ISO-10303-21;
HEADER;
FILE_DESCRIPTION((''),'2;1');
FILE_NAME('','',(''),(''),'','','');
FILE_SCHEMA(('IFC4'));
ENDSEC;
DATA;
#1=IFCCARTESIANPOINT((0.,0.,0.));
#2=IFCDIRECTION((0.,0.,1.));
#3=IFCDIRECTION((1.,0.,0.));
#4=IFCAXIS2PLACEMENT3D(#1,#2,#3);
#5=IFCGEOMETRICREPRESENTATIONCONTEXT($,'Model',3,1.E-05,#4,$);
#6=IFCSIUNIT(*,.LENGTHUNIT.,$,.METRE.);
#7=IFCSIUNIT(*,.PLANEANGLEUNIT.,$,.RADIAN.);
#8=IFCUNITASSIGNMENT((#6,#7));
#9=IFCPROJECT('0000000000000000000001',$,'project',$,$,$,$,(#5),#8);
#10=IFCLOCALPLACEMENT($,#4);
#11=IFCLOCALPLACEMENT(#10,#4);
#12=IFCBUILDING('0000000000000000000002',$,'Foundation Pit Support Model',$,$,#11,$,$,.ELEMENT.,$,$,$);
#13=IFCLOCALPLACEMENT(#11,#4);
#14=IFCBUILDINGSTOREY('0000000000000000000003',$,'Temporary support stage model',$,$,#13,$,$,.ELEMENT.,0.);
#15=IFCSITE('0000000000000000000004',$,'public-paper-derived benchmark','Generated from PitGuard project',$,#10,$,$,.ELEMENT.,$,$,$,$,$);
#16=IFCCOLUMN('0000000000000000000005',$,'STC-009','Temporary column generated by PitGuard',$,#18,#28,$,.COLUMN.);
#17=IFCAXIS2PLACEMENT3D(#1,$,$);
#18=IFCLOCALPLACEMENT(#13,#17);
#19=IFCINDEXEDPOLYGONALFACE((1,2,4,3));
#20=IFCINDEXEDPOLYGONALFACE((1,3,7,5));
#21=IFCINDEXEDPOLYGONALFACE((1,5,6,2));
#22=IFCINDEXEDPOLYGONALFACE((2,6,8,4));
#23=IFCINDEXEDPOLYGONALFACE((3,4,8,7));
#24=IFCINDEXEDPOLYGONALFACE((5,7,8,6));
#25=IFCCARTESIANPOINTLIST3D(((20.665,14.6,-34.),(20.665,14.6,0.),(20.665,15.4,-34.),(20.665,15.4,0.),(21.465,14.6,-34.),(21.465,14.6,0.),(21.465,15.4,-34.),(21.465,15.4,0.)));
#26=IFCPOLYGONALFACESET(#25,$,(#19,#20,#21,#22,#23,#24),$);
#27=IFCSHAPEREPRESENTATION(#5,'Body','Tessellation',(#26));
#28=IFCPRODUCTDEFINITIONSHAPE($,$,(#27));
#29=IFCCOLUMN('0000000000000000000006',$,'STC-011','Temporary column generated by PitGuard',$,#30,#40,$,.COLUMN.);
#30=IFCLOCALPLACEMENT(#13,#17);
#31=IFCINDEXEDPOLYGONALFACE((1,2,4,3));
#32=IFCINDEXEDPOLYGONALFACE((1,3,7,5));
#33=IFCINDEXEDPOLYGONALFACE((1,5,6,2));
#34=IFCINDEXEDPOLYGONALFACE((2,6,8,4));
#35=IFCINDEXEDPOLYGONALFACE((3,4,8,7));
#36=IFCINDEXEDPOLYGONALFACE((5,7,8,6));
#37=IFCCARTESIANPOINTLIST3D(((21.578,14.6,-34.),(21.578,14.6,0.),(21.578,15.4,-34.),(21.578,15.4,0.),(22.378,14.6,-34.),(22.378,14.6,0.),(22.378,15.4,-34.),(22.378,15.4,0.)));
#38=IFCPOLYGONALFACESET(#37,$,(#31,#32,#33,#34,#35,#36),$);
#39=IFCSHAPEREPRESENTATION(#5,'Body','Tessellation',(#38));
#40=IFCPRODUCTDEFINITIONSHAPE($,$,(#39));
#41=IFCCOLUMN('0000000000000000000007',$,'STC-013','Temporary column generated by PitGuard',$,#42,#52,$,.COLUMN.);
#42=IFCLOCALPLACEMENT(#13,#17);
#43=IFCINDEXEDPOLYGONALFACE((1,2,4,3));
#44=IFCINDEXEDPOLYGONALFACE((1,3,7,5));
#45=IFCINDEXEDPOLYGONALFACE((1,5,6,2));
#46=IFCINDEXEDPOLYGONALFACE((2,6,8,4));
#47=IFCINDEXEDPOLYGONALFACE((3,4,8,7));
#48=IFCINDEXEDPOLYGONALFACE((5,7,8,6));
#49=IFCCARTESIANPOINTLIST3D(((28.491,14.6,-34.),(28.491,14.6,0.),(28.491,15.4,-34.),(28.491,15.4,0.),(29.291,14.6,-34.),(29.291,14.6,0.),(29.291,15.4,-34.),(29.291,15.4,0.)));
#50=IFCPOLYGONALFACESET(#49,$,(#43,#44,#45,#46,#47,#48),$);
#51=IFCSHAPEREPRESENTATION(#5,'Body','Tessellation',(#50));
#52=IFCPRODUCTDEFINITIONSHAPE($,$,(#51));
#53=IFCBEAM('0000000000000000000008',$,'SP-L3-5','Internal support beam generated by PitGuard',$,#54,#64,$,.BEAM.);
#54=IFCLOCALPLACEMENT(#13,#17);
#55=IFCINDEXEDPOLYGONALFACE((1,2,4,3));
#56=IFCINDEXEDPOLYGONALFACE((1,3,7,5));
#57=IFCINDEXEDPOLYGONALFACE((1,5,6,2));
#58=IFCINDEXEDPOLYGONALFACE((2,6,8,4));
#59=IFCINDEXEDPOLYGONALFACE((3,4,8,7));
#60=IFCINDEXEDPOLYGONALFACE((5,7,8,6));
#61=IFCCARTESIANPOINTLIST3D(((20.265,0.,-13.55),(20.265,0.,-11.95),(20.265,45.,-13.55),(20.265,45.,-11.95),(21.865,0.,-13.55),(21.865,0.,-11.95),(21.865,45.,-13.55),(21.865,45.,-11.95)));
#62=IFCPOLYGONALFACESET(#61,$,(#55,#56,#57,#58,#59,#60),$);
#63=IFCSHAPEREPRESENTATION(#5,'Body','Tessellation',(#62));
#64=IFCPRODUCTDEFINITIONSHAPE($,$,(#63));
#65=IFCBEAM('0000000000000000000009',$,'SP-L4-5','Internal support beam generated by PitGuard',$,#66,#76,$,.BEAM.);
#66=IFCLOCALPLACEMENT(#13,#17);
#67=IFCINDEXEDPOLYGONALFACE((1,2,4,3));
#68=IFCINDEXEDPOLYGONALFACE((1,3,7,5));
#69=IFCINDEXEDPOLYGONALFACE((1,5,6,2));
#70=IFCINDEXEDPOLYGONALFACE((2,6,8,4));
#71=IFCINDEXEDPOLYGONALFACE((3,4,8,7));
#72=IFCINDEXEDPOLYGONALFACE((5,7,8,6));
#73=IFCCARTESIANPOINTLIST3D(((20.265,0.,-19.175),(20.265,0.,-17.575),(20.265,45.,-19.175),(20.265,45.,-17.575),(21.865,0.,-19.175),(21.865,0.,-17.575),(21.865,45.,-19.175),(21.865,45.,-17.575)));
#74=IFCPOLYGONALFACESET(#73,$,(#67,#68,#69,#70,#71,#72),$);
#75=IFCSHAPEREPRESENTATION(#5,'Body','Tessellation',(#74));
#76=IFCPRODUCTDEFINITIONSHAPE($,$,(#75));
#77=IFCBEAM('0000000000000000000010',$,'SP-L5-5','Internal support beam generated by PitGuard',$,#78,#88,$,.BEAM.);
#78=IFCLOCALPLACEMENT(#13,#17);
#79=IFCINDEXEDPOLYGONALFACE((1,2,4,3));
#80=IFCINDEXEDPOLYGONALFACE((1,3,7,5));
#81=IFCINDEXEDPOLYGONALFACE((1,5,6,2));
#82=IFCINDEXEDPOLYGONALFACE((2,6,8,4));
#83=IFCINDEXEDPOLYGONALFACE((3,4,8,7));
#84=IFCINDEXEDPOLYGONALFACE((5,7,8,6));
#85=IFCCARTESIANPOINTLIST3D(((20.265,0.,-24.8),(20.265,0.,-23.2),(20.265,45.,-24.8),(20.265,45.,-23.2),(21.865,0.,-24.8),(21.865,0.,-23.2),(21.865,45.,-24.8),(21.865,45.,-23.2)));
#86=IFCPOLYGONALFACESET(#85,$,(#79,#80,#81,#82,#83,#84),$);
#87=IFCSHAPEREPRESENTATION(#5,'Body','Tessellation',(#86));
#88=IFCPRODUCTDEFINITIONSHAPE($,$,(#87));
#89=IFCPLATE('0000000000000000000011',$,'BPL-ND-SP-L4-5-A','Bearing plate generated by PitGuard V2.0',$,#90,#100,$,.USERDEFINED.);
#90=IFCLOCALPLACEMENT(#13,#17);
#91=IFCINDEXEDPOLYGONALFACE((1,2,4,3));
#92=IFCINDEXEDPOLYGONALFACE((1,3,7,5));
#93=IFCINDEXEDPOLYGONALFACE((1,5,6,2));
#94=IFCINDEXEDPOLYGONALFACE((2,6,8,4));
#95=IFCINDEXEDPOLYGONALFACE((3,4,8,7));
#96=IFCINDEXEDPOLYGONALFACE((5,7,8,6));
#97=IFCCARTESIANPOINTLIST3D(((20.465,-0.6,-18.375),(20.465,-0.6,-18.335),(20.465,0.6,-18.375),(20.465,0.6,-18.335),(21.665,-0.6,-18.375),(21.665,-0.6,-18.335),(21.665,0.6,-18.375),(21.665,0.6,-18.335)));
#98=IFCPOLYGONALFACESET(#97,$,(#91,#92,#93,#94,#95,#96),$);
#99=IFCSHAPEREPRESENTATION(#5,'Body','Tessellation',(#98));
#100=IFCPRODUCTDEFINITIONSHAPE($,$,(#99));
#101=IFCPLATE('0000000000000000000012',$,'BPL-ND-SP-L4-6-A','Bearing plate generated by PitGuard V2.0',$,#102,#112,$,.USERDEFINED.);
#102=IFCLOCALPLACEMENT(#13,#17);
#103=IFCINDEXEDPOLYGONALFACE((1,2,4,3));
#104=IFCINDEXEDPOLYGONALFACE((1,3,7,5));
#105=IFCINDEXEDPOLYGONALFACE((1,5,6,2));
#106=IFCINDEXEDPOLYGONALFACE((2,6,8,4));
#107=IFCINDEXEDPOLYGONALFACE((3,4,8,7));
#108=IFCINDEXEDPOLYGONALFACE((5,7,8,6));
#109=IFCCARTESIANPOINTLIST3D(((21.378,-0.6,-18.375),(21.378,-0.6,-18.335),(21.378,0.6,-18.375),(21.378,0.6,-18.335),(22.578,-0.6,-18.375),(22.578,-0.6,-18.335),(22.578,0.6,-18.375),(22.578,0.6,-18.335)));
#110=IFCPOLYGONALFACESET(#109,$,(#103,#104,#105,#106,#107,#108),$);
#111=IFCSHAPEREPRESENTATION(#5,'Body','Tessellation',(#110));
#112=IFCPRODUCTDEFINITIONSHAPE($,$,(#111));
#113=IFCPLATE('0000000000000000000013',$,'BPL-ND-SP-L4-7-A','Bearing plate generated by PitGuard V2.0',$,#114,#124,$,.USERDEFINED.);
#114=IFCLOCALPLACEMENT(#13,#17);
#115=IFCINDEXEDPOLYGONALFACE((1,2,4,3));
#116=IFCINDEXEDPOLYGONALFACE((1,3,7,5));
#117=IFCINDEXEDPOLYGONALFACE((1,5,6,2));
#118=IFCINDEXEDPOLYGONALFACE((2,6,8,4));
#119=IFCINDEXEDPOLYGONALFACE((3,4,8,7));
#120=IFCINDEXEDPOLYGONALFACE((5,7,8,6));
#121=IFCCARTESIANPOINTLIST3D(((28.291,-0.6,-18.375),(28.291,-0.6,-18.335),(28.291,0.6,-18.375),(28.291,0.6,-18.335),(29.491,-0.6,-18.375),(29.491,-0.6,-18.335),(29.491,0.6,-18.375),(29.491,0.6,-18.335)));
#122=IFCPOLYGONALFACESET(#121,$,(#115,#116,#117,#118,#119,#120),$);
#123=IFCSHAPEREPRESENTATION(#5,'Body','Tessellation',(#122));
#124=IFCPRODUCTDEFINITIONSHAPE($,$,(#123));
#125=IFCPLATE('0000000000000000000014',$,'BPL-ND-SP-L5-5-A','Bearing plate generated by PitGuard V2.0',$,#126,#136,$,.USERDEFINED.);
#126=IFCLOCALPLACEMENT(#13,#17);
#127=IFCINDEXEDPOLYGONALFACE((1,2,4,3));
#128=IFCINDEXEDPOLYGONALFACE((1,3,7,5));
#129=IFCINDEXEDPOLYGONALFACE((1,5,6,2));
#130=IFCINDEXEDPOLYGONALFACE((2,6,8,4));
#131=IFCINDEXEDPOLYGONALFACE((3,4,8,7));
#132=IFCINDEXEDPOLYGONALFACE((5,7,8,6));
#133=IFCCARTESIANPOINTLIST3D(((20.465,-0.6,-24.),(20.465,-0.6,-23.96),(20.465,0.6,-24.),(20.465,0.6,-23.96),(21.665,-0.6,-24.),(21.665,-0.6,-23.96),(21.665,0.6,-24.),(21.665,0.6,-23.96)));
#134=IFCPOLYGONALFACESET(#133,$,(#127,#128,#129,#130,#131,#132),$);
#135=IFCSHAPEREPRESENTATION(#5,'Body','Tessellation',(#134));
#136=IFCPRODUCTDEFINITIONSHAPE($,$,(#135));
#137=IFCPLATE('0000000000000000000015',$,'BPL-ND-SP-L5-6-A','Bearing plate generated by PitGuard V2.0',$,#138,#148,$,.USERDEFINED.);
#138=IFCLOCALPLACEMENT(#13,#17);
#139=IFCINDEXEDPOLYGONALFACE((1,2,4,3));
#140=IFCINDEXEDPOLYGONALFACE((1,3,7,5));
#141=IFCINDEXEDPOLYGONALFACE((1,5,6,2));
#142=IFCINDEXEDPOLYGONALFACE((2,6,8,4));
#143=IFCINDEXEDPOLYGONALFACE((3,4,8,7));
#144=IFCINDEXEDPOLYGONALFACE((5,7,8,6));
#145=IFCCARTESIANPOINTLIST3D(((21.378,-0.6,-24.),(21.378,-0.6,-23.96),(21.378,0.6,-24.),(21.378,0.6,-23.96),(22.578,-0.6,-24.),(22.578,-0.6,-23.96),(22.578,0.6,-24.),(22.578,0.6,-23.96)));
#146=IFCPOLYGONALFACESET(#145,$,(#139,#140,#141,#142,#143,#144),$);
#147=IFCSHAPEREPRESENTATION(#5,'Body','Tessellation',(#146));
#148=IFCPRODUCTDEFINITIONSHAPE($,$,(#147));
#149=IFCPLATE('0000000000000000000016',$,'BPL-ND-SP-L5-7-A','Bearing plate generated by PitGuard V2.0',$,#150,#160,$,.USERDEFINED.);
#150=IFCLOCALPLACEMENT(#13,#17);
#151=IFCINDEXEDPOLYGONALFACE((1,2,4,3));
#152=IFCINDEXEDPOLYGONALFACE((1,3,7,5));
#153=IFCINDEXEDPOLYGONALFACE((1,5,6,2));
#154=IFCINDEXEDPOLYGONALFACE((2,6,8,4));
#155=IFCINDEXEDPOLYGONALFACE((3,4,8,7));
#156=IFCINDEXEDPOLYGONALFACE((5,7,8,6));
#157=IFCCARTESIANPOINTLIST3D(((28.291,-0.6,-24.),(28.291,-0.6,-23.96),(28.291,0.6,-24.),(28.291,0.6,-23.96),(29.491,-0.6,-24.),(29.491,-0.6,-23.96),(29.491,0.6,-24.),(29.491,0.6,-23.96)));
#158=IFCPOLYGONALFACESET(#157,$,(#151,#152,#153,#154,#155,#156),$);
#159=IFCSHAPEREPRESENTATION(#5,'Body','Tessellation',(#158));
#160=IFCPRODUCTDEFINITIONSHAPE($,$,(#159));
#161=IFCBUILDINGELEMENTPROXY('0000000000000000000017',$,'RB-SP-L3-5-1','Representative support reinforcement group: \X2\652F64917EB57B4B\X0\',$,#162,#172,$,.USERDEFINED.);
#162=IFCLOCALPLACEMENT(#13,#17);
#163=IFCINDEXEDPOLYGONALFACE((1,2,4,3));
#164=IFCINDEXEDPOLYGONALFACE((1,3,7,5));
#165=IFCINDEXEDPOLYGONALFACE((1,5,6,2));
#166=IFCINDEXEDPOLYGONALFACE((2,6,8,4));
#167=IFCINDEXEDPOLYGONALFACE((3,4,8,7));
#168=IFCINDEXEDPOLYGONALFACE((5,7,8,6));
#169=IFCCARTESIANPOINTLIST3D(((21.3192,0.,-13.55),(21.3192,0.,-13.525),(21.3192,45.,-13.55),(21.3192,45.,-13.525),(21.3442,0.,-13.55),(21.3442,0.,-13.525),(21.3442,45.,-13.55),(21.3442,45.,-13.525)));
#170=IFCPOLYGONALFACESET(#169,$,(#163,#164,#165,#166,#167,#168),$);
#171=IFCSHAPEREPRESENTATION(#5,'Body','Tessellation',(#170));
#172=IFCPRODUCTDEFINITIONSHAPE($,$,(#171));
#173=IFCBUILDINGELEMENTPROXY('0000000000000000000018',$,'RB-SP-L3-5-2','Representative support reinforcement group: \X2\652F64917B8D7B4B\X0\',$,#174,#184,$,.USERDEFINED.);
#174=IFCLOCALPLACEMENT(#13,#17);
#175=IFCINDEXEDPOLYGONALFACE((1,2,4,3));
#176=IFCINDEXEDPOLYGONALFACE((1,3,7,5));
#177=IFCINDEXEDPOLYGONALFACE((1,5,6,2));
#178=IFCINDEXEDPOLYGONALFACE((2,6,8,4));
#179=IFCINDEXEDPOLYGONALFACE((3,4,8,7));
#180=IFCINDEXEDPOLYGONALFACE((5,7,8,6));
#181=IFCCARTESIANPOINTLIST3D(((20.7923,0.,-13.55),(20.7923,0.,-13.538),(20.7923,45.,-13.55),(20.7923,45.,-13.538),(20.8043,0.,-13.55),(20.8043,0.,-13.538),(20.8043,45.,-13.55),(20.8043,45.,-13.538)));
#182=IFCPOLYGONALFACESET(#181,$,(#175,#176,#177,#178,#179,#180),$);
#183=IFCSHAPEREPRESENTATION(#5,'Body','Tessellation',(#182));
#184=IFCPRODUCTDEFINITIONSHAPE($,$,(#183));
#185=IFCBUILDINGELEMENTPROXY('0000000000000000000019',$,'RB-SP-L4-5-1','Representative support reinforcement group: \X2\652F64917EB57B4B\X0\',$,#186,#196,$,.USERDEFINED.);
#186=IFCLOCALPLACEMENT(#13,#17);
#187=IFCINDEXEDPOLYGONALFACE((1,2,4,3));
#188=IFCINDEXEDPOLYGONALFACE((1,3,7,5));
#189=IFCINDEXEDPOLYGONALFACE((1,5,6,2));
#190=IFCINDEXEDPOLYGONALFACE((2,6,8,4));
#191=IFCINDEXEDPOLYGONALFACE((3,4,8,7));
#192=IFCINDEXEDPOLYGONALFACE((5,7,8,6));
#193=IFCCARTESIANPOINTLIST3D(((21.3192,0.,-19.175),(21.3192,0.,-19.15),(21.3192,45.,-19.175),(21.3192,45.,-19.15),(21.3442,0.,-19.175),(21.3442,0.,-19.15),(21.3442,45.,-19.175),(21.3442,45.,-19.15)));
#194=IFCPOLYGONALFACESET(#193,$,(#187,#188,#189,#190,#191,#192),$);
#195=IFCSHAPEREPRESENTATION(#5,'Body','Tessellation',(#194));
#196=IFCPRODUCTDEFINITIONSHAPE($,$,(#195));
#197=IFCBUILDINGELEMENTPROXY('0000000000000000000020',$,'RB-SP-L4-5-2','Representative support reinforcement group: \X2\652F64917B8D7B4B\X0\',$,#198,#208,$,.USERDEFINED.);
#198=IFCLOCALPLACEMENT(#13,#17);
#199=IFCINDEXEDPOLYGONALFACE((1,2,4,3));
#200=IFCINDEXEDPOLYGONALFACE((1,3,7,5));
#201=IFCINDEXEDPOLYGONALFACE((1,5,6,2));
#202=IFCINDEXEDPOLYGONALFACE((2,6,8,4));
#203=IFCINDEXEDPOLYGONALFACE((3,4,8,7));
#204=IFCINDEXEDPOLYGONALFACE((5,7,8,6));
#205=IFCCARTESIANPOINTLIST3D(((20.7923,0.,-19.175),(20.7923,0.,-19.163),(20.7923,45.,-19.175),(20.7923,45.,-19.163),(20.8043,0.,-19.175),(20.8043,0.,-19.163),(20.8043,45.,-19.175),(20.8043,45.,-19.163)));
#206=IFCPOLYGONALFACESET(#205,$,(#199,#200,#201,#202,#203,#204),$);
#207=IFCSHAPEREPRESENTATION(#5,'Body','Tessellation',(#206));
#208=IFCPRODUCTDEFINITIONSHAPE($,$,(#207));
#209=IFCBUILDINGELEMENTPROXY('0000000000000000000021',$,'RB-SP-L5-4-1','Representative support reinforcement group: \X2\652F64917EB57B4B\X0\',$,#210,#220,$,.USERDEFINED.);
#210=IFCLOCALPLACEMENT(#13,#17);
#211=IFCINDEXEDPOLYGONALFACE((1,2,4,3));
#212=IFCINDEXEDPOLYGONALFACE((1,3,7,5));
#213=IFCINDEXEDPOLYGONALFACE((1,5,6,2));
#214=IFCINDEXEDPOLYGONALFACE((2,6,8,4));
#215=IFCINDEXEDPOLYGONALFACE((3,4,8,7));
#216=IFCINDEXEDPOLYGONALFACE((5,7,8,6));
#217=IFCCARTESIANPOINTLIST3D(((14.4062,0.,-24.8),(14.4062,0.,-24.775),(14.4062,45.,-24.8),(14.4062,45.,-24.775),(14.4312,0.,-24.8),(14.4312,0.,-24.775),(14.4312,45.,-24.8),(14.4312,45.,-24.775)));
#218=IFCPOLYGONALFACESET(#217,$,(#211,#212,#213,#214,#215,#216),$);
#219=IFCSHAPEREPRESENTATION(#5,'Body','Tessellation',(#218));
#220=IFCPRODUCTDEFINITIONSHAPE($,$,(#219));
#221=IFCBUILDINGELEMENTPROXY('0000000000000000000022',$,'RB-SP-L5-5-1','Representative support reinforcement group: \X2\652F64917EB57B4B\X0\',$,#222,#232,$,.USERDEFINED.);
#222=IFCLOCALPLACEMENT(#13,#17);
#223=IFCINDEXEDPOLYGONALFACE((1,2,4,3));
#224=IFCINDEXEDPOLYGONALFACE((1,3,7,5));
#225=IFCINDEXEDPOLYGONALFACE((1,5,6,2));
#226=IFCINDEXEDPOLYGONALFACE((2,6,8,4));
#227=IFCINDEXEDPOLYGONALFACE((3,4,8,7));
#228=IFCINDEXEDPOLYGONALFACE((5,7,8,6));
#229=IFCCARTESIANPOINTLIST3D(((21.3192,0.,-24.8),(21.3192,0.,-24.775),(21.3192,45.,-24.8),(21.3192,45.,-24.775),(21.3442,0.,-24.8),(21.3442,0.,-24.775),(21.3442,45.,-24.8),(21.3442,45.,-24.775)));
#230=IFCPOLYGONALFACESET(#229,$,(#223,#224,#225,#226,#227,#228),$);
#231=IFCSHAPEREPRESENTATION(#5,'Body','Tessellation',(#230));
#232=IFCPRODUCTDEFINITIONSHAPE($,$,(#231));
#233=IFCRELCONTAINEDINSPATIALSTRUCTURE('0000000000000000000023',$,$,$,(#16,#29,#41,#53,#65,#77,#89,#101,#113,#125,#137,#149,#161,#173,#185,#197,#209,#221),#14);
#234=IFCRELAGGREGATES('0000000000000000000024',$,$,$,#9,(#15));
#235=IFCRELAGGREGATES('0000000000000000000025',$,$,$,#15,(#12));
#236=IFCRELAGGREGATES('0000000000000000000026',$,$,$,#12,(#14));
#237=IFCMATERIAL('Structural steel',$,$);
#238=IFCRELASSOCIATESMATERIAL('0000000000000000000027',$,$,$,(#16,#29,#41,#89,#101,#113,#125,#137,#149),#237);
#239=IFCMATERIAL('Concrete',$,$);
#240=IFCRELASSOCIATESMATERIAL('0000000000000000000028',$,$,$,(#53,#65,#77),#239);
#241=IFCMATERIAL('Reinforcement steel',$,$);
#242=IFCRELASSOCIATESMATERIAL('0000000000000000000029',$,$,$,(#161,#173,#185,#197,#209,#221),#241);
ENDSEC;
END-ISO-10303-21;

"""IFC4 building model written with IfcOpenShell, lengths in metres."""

from ifc_helpers import new_model, si_unit, frame, origin_with_axes, origin_2d, place, context, project, spatial, rectangle, extrude, material, element, save


model = new_model("IFC4")

# Units and contexts
model_context = context("Model", 3, precision=1e-05, world=origin_with_axes())
ifc_project = project(units=[si_unit("LENGTHUNIT", "METRE"), si_unit("PLANEANGLEUNIT", "RADIAN")], contexts=[model_context])

# Site, building, storey
site_placement = place(None, origin_with_axes())
site = spatial("IfcSite", under=ifc_project, at=site_placement, Name="public-paper-derived benchmark", Description="Generated from PitGuard project", CompositionType="ELEMENT")
building_placement = place(site_placement, origin_with_axes())
building = spatial("IfcBuilding", under=site, at=building_placement, Name="Foundation Pit Support Model", CompositionType="ELEMENT")
storey_placement = place(building_placement, origin_with_axes())
storey = spatial("IfcBuildingStorey", under=building, at=storey_placement, Name="Temporary support stage model", CompositionType="ELEMENT", Elevation=0.0)

# Columns
ifc_material_1 = material(Name="Structural steel")
for number, where, z_axis, x_axis, name in (
    (1, (21.065, 15.0, -34.0), (0.0, 0.0, 1.0), (1.0, 0.0, 0.0), "STC-009"),
    (2, (21.978, 15.0, -34.0), (0.0, 0.0, 1.0), (1.0, 0.0, 0.0), "STC-011"),
    (3, (28.891, 15.0, -34.0), (0.0, 0.0, 1.0), (1.0, 0.0, 0.0), "STC-013"),
):
    element("IfcColumn", number, at=place(storey_placement, frame(where, z_axis=z_axis, x_axis=x_axis)), inside=storey, material=ifc_material_1, Name=name, Description="Temporary column generated by PitGuard", PredefinedType="COLUMN", context=model_context, shape_type="SweptSolid", body=[
        extrude(rectangle(XDim=0.8, YDim=0.8, at=origin_2d()), origin_with_axes(), (0.0, 0.0, 1.0), 34.0),
    ])

# Beams
ifc_material_2 = material(Name="Concrete")
for number, where, z_axis, x_axis, name in (
    (4, (21.065, 22.5, -13.55), (0.0, 0.0, 1.0), (0.0, 1.0, 0.0), "SP-L3-5"),
    (5, (21.065, 22.5, -19.175), (0.0, 0.0, 1.0), (0.0, 1.0, 0.0), "SP-L4-5"),
    (6, (21.065, 22.5, -24.8), (0.0, 0.0, 1.0), (0.0, 1.0, 0.0), "SP-L5-5"),
):
    element("IfcBeam", number, at=place(storey_placement, frame(where, z_axis=z_axis, x_axis=x_axis)), inside=storey, material=ifc_material_2, Name=name, Description="Internal support beam generated by PitGuard", PredefinedType="BEAM", context=model_context, shape_type="SweptSolid", body=[
        extrude(rectangle(XDim=45.0, YDim=1.6, at=origin_2d()), origin_with_axes(), (0.0, 0.0, 1.0), 1.6),
    ])

# Plates
for number, where, z_axis, x_axis, name in (
    (7, (21.065, 0.0, -18.375), (0.0, 0.0, 1.0), (1.0, 0.0, 0.0), "BPL-ND-SP-L4-5-A"),
    (8, (21.978, 0.0, -18.375), (0.0, 0.0, 1.0), (1.0, 0.0, 0.0), "BPL-ND-SP-L4-6-A"),
    (9, (28.891, 0.0, -18.375), (0.0, 0.0, 1.0), (1.0, 0.0, 0.0), "BPL-ND-SP-L4-7-A"),
    (10, (21.065, 0.0, -24.0), (0.0, 0.0, 1.0), (1.0, 0.0, 0.0), "BPL-ND-SP-L5-5-A"),
    (11, (21.978, 0.0, -24.0), (0.0, 0.0, 1.0), (1.0, 0.0, 0.0), "BPL-ND-SP-L5-6-A"),
    (12, (28.891, 0.0, -24.0), (0.0, 0.0, 1.0), (1.0, 0.0, 0.0), "BPL-ND-SP-L5-7-A"),
):
    element("IfcPlate", number, at=place(storey_placement, frame(where, z_axis=z_axis, x_axis=x_axis)), inside=storey, material=ifc_material_1, Name=name, Description="Bearing plate generated by PitGuard V2.0", PredefinedType="USERDEFINED", context=model_context, shape_type="SweptSolid", body=[
        extrude(rectangle(XDim=1.2, YDim=1.2, at=origin_2d()), origin_with_axes(), (0.0, 0.0, 1.0), 0.04),
    ])

# Building element proxies
ifc_material_3 = material(Name="Reinforcement steel")
proxy_1_placement = place(storey_placement, frame((21.3317, 22.5, -13.55), z_axis=(0.0, 0.0, 1.0), x_axis=(0.0, 1.0, 0.0)))
element("IfcBuildingElementProxy", 13, at=proxy_1_placement, inside=storey, material=ifc_material_3, Name="RB-SP-L3-5-1", Description="Representative support reinforcement group: 支撑纵筋", PredefinedType="USERDEFINED", context=model_context, shape_type="SweptSolid", body=[
    extrude(rectangle(XDim=45.0, YDim=0.025, at=origin_2d()), origin_with_axes(), (0.0, 0.0, 1.0), 0.025),
])
proxy_2_placement = place(storey_placement, frame((20.7983, 22.5, -13.55), z_axis=(0.0, 0.0, 1.0), x_axis=(0.0, 1.0, 0.0)))
element("IfcBuildingElementProxy", 14, at=proxy_2_placement, inside=storey, material=ifc_material_3, Name="RB-SP-L3-5-2", Description="Representative support reinforcement group: 支撑箍筋", PredefinedType="USERDEFINED", context=model_context, shape_type="SweptSolid", body=[
    extrude(rectangle(XDim=45.0, YDim=0.012, at=origin_2d()), origin_with_axes(), (0.0, 0.0, 1.0), 0.012),
])
proxy_3_placement = place(storey_placement, frame((21.3317, 22.5, -19.175), z_axis=(0.0, 0.0, 1.0), x_axis=(0.0, 1.0, 0.0)))
element("IfcBuildingElementProxy", 15, at=proxy_3_placement, inside=storey, material=ifc_material_3, Name="RB-SP-L4-5-1", Description="Representative support reinforcement group: 支撑纵筋", PredefinedType="USERDEFINED", context=model_context, shape_type="SweptSolid", body=[
    extrude(rectangle(XDim=45.0, YDim=0.025, at=origin_2d()), origin_with_axes(), (0.0, 0.0, 1.0), 0.025),
])
proxy_4_placement = place(storey_placement, frame((20.7983, 22.5, -19.175), z_axis=(0.0, 0.0, 1.0), x_axis=(0.0, 1.0, 0.0)))
element("IfcBuildingElementProxy", 16, at=proxy_4_placement, inside=storey, material=ifc_material_3, Name="RB-SP-L4-5-2", Description="Representative support reinforcement group: 支撑箍筋", PredefinedType="USERDEFINED", context=model_context, shape_type="SweptSolid", body=[
    extrude(rectangle(XDim=45.0, YDim=0.012, at=origin_2d()), origin_with_axes(), (0.0, 0.0, 1.0), 0.012),
])
for number, where, z_axis, x_axis, name in (
    (17, (14.4187, 22.5, -24.8), (0.0, 0.0, 1.0), (0.0, 1.0, 0.0), "RB-SP-L5-4-1"),
    (18, (21.3317, 22.5, -24.8), (0.0, 0.0, 1.0), (0.0, 1.0, 0.0), "RB-SP-L5-5-1"),
):
    element("IfcBuildingElementProxy", number, at=place(storey_placement, frame(where, z_axis=z_axis, x_axis=x_axis)), inside=storey, material=ifc_material_3, Name=name, Description="Representative support reinforcement group: 支撑纵筋", PredefinedType="USERDEFINED", context=model_context, shape_type="SweptSolid", body=[
        extrude(rectangle(XDim=45.0, YDim=0.025, at=origin_2d()), origin_with_axes(), (0.0, 0.0, 1.0), 0.025),
    ])

save(model, "model.ifc")
